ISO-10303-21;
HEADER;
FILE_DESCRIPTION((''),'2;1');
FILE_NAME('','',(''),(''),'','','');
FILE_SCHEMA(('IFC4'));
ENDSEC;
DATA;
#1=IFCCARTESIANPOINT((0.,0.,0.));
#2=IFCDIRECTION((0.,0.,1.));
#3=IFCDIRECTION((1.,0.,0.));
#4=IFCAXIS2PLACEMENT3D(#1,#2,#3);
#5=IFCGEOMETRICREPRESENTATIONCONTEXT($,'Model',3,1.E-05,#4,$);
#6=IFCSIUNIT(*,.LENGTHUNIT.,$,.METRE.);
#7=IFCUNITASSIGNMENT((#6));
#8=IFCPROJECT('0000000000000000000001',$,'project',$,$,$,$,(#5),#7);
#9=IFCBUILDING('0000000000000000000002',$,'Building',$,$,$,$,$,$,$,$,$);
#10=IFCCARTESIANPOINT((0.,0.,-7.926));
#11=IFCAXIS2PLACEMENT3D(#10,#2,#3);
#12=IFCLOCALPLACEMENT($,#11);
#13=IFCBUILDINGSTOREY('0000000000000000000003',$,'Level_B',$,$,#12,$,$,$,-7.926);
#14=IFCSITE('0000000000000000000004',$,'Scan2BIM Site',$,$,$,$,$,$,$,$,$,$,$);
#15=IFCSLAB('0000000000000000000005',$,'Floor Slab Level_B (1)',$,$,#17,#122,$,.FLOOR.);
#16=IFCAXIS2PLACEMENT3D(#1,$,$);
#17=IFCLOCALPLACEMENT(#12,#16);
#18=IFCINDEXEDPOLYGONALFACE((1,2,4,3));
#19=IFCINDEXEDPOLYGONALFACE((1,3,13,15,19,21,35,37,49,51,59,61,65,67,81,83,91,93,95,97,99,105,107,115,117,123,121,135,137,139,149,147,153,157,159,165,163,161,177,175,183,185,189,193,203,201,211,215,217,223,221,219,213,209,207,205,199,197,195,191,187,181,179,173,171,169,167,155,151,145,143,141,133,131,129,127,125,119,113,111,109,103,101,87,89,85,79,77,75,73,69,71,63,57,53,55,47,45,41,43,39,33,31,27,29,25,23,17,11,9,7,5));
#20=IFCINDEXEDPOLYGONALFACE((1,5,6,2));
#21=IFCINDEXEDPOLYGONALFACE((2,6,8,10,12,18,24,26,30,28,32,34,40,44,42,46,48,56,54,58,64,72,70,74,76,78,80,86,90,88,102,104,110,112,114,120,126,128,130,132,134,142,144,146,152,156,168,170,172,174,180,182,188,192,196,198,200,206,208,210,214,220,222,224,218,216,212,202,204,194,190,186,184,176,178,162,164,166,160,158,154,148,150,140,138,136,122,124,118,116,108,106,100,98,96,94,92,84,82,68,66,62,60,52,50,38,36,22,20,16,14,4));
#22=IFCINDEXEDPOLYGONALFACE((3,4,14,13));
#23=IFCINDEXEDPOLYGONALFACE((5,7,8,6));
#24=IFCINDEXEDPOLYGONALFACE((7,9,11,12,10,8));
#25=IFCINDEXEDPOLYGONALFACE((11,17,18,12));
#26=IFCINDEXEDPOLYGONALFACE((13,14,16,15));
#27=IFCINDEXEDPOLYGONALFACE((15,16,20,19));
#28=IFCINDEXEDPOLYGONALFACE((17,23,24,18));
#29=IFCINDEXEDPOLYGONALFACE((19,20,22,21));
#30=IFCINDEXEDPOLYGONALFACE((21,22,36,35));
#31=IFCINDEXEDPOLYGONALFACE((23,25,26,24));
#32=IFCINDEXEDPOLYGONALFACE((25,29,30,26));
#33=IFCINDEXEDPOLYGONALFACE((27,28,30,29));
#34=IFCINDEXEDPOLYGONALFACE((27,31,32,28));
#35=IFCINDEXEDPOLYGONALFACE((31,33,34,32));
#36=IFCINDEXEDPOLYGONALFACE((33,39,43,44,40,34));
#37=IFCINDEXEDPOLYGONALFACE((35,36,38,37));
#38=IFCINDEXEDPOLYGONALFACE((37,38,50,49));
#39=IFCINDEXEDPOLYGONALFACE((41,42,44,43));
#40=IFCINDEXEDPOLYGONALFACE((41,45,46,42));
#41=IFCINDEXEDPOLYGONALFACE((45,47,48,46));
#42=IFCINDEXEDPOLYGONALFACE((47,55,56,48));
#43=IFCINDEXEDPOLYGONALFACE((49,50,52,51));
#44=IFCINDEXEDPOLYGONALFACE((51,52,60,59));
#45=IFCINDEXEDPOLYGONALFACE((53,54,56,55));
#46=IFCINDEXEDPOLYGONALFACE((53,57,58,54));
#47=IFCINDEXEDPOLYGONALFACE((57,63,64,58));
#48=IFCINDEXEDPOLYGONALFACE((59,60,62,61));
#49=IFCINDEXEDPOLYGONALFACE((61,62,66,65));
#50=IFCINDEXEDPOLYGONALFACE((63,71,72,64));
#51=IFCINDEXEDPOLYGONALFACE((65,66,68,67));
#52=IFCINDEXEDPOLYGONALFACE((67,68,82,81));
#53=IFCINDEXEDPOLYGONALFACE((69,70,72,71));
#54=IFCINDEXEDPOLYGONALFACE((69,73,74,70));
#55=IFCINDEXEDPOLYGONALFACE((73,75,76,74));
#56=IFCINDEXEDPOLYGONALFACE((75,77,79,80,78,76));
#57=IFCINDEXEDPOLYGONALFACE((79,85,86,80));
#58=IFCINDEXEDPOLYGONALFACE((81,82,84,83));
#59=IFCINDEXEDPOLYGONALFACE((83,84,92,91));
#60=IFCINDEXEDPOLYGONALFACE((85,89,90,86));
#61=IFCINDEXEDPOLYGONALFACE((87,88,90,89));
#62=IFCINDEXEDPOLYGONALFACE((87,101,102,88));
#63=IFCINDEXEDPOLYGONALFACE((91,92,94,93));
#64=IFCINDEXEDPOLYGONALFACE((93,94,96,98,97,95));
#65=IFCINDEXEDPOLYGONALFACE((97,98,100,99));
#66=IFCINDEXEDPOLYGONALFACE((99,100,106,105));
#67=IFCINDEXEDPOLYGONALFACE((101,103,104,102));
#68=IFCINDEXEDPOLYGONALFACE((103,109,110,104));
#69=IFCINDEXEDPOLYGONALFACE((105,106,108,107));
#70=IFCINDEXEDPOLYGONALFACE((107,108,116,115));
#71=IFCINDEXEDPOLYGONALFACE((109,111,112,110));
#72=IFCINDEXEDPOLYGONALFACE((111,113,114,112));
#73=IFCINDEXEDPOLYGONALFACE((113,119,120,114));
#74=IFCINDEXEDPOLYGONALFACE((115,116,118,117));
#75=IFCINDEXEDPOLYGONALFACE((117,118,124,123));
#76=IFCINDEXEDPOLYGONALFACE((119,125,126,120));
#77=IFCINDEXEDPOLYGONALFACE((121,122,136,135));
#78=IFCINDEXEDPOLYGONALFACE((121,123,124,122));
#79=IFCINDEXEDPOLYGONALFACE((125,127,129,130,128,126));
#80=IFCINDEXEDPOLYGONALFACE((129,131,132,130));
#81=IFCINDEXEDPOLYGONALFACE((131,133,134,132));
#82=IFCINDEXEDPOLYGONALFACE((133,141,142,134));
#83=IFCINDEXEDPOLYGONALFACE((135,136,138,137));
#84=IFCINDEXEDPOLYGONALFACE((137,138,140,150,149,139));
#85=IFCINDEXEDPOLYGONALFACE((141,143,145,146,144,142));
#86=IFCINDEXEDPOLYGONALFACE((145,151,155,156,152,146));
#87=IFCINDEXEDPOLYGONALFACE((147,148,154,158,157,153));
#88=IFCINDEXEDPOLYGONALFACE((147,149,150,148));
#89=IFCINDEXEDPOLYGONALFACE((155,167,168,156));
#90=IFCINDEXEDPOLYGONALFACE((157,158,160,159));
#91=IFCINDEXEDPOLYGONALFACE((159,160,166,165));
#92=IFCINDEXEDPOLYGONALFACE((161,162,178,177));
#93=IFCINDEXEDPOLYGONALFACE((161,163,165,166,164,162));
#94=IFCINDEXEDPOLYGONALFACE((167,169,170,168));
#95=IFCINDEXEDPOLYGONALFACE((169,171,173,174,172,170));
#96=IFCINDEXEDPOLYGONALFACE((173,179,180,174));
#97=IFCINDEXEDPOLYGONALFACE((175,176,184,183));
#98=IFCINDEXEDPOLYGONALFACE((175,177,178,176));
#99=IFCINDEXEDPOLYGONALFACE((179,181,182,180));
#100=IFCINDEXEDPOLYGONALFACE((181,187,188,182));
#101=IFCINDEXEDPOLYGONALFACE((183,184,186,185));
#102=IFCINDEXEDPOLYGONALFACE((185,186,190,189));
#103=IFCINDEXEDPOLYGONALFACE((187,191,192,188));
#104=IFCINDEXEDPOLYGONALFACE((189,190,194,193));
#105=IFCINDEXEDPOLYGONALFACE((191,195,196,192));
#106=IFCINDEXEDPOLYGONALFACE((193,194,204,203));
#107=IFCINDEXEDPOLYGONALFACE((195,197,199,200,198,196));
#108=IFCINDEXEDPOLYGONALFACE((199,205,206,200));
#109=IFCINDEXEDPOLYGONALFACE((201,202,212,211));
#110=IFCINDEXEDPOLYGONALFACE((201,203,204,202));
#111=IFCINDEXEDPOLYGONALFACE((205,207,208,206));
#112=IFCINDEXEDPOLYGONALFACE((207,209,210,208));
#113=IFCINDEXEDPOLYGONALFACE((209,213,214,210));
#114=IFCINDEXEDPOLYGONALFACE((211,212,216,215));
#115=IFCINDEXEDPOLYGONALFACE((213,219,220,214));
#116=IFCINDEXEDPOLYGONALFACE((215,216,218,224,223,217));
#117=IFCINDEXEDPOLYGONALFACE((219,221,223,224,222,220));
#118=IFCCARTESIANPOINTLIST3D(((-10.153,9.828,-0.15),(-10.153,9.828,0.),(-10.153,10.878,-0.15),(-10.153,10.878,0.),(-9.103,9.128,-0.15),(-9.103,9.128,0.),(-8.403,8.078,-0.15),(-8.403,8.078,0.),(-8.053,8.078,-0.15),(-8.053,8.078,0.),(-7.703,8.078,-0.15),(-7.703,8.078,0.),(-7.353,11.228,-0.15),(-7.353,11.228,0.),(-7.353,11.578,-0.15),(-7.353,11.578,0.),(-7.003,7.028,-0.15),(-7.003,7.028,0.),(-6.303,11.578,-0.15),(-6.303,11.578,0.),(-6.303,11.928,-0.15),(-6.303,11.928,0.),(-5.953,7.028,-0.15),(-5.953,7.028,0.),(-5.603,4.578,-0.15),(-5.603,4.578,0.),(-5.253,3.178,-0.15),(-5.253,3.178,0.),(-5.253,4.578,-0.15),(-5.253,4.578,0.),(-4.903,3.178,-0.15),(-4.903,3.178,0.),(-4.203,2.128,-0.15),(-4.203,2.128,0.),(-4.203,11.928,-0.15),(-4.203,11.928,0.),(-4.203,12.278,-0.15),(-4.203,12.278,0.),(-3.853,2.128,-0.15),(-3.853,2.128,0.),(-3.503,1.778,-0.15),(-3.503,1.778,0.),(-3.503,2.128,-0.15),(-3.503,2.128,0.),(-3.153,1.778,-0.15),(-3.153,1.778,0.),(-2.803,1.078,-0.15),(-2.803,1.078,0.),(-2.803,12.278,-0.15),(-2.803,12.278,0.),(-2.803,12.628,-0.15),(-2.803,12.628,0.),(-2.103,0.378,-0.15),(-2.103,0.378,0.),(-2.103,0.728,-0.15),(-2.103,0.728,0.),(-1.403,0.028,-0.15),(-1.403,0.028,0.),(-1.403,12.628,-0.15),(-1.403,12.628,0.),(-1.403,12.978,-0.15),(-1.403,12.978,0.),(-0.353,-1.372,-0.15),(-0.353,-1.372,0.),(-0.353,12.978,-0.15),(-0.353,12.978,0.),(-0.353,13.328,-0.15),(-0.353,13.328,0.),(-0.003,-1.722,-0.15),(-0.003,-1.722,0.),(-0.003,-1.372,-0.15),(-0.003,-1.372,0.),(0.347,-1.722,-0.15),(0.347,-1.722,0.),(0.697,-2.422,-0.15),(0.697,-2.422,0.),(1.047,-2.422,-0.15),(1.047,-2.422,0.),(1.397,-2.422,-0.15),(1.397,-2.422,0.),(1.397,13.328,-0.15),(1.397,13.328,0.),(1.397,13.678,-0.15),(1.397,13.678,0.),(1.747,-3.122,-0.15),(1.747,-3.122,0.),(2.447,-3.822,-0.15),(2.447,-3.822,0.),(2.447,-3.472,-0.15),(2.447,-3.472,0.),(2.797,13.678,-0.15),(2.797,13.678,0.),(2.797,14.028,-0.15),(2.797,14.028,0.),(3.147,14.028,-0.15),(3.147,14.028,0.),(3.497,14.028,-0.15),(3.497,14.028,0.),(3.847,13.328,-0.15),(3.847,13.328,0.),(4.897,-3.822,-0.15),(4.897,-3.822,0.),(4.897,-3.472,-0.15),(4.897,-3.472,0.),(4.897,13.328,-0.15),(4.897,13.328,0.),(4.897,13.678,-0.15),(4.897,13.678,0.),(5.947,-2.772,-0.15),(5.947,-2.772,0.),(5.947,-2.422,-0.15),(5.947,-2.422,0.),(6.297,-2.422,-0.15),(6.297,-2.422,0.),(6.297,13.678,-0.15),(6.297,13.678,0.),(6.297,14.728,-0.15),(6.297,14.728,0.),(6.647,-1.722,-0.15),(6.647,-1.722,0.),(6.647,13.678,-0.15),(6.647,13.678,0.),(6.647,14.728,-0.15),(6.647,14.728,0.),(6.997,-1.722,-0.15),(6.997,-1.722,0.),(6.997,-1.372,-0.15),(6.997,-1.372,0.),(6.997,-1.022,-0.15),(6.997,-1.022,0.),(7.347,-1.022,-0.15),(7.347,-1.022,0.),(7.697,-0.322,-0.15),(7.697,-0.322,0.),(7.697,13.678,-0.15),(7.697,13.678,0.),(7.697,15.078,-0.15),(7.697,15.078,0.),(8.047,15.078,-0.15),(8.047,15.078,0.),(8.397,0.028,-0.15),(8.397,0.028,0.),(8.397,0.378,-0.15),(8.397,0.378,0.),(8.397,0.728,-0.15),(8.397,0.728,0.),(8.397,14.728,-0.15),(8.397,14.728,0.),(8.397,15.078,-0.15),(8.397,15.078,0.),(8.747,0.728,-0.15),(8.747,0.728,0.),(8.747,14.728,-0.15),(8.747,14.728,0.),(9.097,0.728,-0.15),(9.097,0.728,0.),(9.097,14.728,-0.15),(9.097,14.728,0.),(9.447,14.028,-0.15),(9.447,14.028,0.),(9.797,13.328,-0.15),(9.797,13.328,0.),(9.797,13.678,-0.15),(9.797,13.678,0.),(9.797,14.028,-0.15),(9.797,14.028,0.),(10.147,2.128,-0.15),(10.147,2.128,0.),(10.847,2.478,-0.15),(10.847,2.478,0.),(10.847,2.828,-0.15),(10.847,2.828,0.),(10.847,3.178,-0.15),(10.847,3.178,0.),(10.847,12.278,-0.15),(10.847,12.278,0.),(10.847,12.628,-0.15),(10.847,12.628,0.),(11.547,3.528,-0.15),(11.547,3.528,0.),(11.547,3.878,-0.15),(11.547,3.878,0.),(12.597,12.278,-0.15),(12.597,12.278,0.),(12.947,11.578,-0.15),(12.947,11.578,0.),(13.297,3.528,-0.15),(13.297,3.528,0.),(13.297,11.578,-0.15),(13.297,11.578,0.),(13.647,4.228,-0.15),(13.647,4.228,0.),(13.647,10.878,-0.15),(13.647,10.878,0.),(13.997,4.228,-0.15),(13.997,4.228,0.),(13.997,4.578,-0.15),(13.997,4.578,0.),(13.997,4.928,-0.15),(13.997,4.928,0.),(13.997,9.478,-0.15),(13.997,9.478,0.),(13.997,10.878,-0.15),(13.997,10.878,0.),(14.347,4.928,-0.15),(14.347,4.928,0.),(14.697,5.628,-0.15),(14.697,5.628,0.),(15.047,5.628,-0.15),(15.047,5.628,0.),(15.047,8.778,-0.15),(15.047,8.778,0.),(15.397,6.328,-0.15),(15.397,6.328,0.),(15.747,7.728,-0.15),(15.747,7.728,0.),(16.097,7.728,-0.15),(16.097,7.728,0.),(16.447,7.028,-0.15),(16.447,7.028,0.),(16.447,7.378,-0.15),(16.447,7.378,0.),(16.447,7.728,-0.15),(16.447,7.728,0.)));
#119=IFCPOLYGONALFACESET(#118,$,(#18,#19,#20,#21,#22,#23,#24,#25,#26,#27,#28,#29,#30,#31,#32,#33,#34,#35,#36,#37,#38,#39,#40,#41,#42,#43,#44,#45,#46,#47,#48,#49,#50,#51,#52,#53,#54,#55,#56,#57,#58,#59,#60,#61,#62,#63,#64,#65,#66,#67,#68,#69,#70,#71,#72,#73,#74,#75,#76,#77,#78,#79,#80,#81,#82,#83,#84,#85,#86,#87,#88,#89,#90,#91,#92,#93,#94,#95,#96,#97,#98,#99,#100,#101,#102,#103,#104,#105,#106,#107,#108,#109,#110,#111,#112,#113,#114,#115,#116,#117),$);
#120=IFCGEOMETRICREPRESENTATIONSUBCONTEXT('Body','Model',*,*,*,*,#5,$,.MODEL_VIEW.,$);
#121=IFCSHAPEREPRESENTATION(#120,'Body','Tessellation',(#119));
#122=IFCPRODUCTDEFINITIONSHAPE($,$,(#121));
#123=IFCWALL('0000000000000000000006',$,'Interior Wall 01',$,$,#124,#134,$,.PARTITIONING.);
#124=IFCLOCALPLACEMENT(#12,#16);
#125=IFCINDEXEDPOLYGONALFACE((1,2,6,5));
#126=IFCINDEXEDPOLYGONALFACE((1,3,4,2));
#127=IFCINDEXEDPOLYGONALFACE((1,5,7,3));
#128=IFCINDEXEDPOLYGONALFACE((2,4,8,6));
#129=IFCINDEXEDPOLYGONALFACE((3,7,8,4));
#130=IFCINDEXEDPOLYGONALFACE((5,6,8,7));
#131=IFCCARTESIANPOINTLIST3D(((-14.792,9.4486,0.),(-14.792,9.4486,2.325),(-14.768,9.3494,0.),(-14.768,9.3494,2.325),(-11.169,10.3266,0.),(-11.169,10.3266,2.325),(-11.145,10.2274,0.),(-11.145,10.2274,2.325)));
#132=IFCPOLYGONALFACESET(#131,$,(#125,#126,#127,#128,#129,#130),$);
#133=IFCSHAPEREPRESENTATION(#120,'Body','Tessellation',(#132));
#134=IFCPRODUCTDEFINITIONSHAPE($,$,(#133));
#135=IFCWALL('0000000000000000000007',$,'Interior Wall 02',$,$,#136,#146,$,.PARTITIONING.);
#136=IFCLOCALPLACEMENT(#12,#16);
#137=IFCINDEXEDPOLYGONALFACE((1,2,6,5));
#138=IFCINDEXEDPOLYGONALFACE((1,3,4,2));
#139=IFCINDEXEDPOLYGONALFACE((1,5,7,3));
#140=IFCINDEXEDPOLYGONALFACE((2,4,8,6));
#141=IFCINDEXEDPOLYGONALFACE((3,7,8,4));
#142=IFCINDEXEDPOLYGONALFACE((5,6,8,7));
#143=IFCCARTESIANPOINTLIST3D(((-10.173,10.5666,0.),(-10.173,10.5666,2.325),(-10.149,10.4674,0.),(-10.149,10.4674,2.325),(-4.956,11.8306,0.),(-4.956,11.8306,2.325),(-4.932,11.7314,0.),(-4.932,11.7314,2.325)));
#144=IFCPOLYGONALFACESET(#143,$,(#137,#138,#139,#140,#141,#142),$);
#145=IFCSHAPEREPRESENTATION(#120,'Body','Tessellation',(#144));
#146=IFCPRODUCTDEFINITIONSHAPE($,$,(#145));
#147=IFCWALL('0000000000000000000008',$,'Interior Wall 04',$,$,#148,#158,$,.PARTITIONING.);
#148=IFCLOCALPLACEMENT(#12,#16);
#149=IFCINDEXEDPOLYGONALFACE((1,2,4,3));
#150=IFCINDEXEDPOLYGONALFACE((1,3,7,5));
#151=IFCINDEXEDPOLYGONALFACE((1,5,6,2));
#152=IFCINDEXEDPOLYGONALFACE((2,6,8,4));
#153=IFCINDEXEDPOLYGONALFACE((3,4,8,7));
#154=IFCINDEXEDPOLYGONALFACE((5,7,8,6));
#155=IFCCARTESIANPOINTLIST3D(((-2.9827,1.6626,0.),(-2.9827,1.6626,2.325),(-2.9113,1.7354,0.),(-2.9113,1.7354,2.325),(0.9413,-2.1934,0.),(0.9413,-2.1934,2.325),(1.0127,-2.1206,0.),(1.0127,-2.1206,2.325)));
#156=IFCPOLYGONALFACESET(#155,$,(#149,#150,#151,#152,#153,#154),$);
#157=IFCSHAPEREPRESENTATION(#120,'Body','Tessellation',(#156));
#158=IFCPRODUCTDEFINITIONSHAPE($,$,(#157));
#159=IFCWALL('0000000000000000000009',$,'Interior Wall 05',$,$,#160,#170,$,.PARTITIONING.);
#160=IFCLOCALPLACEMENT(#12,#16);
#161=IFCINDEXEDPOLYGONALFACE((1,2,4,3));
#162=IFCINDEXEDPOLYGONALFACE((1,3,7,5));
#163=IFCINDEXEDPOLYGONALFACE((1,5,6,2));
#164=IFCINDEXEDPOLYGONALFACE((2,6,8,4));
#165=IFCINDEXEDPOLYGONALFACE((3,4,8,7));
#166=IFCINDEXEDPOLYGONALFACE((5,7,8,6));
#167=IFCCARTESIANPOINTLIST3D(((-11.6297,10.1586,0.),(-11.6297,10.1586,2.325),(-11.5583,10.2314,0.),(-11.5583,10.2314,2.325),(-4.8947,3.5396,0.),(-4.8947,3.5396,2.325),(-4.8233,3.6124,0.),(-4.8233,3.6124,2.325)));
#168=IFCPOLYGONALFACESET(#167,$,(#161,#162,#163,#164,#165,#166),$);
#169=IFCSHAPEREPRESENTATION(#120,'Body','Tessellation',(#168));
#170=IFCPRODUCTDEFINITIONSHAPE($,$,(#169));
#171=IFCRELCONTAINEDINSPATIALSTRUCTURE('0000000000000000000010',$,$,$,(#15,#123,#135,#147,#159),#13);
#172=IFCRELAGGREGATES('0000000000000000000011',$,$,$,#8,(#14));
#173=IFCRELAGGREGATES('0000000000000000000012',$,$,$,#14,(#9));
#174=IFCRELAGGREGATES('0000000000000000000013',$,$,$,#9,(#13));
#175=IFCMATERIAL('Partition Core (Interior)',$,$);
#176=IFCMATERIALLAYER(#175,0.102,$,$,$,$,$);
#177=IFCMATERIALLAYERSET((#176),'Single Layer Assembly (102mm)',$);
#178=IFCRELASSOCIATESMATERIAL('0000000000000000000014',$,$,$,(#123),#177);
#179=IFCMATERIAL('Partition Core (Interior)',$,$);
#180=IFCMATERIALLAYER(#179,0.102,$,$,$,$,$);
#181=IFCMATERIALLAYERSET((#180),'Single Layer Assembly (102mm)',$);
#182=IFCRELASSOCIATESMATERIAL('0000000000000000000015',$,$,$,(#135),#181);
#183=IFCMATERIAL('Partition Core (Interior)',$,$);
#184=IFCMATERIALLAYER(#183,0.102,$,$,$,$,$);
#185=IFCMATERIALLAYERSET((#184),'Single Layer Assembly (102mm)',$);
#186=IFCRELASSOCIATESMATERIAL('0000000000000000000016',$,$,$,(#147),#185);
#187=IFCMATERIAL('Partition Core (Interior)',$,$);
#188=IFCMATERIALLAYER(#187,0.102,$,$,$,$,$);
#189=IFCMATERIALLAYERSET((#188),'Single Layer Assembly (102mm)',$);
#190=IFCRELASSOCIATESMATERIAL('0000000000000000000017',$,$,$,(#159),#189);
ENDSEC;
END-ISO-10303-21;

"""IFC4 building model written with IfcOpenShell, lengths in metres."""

from ifc_helpers import new_model, si_unit, frame, origin, origin_with_axes, place, context, subcontext, project, spatial, polyline, rectangle, outline, extrude, material, layer, layer_set, element, save


model = new_model("IFC4")

# Units and contexts
model_context = context("Model", 3, precision=1e-05, world=origin_with_axes())
body_context = subcontext(model_context, "Body", "Model", "MODEL_VIEW")
ifc_project = project(units=[si_unit("LENGTHUNIT", "METRE")], contexts=[model_context])

# Site, building, storey
site = spatial("IfcSite", under=ifc_project, Name="Scan2BIM Site")
building = spatial("IfcBuilding", under=site, Name="Building")
storey_placement = place(None, frame((0.0, 0.0, -7.926), z_axis=(0.0, 0.0, 1.0), x_axis=(1.0, 0.0, 0.0)))
storey = spatial("IfcBuildingStorey", under=building, at=storey_placement, Name="Level_B", Elevation=-7.926)

# Slab
slab_placement = place(storey_placement, frame((0.0, 0.0, -0.15), z_axis=(0.0, 0.0, 1.0), x_axis=(1.0, 0.0, 0.0)))
element("IfcSlab", 1, at=slab_placement, inside=storey, Name="Floor Slab Level_B (1)", PredefinedType="FLOOR", context=body_context, shape_type="SweptSolid", body=[
    extrude(outline(polyline([(2.447, -3.822), (4.897, -3.822), (4.897, -3.472), (5.947, -2.772), (5.947, -2.422), (6.297, -2.422), (6.647, -1.722), (6.997, -1.722), (6.997, -1.372), (6.997, -1.022), (7.347, -1.022), (7.697, -0.322), (8.397, 0.028), (8.397, 0.378), (8.397, 0.728), (8.747, 0.728), (9.097, 0.728), (10.147, 2.128), (10.847, 2.478), (10.847, 2.828), (10.847, 3.178), (11.547, 3.528), (11.547, 3.878), (13.297, 3.528), (13.647, 4.228), (13.997, 4.228), (13.997, 4.578), (13.997, 4.928), (14.347, 4.928), (14.697, 5.628), (15.047, 5.628), (15.397, 6.328), (16.447, 7.028), (16.447, 7.378), (16.447, 7.728), (16.097, 7.728), (15.747, 7.728), (15.047, 8.778), (13.997, 9.478), (13.997, 10.878), (13.647, 10.878), (13.297, 11.578), (12.947, 11.578), (12.597, 12.278), (10.847, 12.278), (10.847, 12.628), (9.797, 13.328), (9.797, 13.678), (9.797, 14.028), (9.447, 14.028), (9.097, 14.728), (8.747, 14.728), (8.397, 14.728), (8.397, 15.078), (8.047, 15.078), (7.697, 15.078), (7.697, 13.678), (6.647, 13.678), (6.647, 14.728), (6.297, 14.728), (6.297, 13.678), (4.897, 13.678), (4.897, 13.328), (3.847, 13.328), (3.497, 14.028), (3.147, 14.028), (2.797, 14.028), (2.797, 13.678), (1.397, 13.678), (1.397, 13.328), (-0.353, 13.328), (-0.353, 12.978), (-1.403, 12.978), (-1.403, 12.628), (-2.803, 12.628), (-2.803, 12.278), (-4.203, 12.278), (-4.203, 11.928), (-6.303, 11.928), (-6.303, 11.578), (-7.353, 11.578), (-7.353, 11.228), (-10.153, 10.878), (-10.153, 9.828), (-9.103, 9.128), (-8.403, 8.078), (-8.053, 8.078), (-7.703, 8.078), (-7.003, 7.028), (-5.953, 7.028), (-5.603, 4.578), (-5.253, 4.578), (-5.253, 3.178), (-4.903, 3.178), (-4.203, 2.128), (-3.853, 2.128), (-3.503, 2.128), (-3.503, 1.778), (-3.153, 1.778), (-2.803, 1.078), (-2.103, 0.728), (-2.103, 0.378), (-1.403, 0.028), (-0.353, -1.372), (-0.003, -1.372), (-0.003, -1.722), (0.347, -1.722), (0.697, -2.422), (1.047, -2.422), (1.397, -2.422), (1.747, -3.122), (2.447, -3.472), (2.447, -3.822)])), origin(), (0.0, 0.0, 1.0), 0.15),
])

# Walls
ifc_material_1 = material(Name="Partition Core (Interior)")
ifc_layer_1 = layer(ifc_material_1, 0.102)
ifc_layer_set_1 = layer_set([ifc_layer_1], Name="Single Layer Assembly (102mm)")
wall_1_placement = place(storey_placement, frame((-12.9685, 9.838, 0.0), z_axis=(0.0, 0.0, 1.0), x_axis=(0.971869, 0.235523, 0.0)))
element("IfcWall", 2, at=wall_1_placement, inside=storey, material=ifc_layer_set_1, Name="Interior Wall 01", PredefinedType="PARTITIONING", context=body_context, shape_type="SweptSolid", body=[
    extrude(rectangle(XDim=3.7279, YDim=0.102), origin(), (0.0, 0.0, 1.0), 2.325),
])
ifc_material_2 = material(Name="Partition Core (Interior)")
ifc_layer_2 = layer(ifc_material_2, 0.102)
ifc_layer_set_2 = layer_set([ifc_layer_2], Name="Single Layer Assembly (102mm)")
wall_2_placement = place(storey_placement, frame((-7.5525, 11.149, 0.0), z_axis=(0.0, 0.0, 1.0), x_axis=(0.971881, 0.235472, 0.0)))
element("IfcWall", 3, at=wall_2_placement, inside=storey, material=ifc_layer_set_2, Name="Interior Wall 02", PredefinedType="PARTITIONING", context=body_context, shape_type="SweptSolid", body=[
    extrude(rectangle(XDim=5.3679, YDim=0.102), origin(), (0.0, 0.0, 1.0), 2.325),
])
ifc_material_3 = material(Name="Partition Core (Interior)")
ifc_layer_3 = layer(ifc_material_3, 0.102)
ifc_layer_set_3 = layer_set([ifc_layer_3], Name="Single Layer Assembly (102mm)")
wall_3_placement = place(storey_placement, frame((-0.985, -0.229, 0.0), z_axis=(0.0, 0.0, 1.0), x_axis=(-0.71326, 0.7009, 0.0)))
element("IfcWall", 4, at=wall_3_placement, inside=storey, material=ifc_layer_set_3, Name="Interior Wall 04", PredefinedType="PARTITIONING", context=body_context, shape_type="SweptSolid", body=[
    extrude(rectangle(XDim=5.5015, YDim=0.102), origin(), (0.0, 0.0, 1.0), 2.325),
])
ifc_material_4 = material(Name="Partition Core (Interior)")
ifc_layer_4 = layer(ifc_material_4, 0.102)
ifc_layer_set_4 = layer_set([ifc_layer_4], Name="Single Layer Assembly (102mm)")
wall_4_placement = place(storey_placement, frame((-8.2265, 6.8855, 0.0), z_axis=(0.0, 0.0, 1.0), x_axis=(-0.713222, 0.700938, 0.0)))
element("IfcWall", 5, at=wall_4_placement, inside=storey, material=ifc_layer_set_4, Name="Interior Wall 05", PredefinedType="PARTITIONING", context=body_context, shape_type="SweptSolid", body=[
    extrude(rectangle(XDim=9.4431, YDim=0.102), origin(), (0.0, 0.0, 1.0), 2.325),
])

save(model, "model.ifc")
